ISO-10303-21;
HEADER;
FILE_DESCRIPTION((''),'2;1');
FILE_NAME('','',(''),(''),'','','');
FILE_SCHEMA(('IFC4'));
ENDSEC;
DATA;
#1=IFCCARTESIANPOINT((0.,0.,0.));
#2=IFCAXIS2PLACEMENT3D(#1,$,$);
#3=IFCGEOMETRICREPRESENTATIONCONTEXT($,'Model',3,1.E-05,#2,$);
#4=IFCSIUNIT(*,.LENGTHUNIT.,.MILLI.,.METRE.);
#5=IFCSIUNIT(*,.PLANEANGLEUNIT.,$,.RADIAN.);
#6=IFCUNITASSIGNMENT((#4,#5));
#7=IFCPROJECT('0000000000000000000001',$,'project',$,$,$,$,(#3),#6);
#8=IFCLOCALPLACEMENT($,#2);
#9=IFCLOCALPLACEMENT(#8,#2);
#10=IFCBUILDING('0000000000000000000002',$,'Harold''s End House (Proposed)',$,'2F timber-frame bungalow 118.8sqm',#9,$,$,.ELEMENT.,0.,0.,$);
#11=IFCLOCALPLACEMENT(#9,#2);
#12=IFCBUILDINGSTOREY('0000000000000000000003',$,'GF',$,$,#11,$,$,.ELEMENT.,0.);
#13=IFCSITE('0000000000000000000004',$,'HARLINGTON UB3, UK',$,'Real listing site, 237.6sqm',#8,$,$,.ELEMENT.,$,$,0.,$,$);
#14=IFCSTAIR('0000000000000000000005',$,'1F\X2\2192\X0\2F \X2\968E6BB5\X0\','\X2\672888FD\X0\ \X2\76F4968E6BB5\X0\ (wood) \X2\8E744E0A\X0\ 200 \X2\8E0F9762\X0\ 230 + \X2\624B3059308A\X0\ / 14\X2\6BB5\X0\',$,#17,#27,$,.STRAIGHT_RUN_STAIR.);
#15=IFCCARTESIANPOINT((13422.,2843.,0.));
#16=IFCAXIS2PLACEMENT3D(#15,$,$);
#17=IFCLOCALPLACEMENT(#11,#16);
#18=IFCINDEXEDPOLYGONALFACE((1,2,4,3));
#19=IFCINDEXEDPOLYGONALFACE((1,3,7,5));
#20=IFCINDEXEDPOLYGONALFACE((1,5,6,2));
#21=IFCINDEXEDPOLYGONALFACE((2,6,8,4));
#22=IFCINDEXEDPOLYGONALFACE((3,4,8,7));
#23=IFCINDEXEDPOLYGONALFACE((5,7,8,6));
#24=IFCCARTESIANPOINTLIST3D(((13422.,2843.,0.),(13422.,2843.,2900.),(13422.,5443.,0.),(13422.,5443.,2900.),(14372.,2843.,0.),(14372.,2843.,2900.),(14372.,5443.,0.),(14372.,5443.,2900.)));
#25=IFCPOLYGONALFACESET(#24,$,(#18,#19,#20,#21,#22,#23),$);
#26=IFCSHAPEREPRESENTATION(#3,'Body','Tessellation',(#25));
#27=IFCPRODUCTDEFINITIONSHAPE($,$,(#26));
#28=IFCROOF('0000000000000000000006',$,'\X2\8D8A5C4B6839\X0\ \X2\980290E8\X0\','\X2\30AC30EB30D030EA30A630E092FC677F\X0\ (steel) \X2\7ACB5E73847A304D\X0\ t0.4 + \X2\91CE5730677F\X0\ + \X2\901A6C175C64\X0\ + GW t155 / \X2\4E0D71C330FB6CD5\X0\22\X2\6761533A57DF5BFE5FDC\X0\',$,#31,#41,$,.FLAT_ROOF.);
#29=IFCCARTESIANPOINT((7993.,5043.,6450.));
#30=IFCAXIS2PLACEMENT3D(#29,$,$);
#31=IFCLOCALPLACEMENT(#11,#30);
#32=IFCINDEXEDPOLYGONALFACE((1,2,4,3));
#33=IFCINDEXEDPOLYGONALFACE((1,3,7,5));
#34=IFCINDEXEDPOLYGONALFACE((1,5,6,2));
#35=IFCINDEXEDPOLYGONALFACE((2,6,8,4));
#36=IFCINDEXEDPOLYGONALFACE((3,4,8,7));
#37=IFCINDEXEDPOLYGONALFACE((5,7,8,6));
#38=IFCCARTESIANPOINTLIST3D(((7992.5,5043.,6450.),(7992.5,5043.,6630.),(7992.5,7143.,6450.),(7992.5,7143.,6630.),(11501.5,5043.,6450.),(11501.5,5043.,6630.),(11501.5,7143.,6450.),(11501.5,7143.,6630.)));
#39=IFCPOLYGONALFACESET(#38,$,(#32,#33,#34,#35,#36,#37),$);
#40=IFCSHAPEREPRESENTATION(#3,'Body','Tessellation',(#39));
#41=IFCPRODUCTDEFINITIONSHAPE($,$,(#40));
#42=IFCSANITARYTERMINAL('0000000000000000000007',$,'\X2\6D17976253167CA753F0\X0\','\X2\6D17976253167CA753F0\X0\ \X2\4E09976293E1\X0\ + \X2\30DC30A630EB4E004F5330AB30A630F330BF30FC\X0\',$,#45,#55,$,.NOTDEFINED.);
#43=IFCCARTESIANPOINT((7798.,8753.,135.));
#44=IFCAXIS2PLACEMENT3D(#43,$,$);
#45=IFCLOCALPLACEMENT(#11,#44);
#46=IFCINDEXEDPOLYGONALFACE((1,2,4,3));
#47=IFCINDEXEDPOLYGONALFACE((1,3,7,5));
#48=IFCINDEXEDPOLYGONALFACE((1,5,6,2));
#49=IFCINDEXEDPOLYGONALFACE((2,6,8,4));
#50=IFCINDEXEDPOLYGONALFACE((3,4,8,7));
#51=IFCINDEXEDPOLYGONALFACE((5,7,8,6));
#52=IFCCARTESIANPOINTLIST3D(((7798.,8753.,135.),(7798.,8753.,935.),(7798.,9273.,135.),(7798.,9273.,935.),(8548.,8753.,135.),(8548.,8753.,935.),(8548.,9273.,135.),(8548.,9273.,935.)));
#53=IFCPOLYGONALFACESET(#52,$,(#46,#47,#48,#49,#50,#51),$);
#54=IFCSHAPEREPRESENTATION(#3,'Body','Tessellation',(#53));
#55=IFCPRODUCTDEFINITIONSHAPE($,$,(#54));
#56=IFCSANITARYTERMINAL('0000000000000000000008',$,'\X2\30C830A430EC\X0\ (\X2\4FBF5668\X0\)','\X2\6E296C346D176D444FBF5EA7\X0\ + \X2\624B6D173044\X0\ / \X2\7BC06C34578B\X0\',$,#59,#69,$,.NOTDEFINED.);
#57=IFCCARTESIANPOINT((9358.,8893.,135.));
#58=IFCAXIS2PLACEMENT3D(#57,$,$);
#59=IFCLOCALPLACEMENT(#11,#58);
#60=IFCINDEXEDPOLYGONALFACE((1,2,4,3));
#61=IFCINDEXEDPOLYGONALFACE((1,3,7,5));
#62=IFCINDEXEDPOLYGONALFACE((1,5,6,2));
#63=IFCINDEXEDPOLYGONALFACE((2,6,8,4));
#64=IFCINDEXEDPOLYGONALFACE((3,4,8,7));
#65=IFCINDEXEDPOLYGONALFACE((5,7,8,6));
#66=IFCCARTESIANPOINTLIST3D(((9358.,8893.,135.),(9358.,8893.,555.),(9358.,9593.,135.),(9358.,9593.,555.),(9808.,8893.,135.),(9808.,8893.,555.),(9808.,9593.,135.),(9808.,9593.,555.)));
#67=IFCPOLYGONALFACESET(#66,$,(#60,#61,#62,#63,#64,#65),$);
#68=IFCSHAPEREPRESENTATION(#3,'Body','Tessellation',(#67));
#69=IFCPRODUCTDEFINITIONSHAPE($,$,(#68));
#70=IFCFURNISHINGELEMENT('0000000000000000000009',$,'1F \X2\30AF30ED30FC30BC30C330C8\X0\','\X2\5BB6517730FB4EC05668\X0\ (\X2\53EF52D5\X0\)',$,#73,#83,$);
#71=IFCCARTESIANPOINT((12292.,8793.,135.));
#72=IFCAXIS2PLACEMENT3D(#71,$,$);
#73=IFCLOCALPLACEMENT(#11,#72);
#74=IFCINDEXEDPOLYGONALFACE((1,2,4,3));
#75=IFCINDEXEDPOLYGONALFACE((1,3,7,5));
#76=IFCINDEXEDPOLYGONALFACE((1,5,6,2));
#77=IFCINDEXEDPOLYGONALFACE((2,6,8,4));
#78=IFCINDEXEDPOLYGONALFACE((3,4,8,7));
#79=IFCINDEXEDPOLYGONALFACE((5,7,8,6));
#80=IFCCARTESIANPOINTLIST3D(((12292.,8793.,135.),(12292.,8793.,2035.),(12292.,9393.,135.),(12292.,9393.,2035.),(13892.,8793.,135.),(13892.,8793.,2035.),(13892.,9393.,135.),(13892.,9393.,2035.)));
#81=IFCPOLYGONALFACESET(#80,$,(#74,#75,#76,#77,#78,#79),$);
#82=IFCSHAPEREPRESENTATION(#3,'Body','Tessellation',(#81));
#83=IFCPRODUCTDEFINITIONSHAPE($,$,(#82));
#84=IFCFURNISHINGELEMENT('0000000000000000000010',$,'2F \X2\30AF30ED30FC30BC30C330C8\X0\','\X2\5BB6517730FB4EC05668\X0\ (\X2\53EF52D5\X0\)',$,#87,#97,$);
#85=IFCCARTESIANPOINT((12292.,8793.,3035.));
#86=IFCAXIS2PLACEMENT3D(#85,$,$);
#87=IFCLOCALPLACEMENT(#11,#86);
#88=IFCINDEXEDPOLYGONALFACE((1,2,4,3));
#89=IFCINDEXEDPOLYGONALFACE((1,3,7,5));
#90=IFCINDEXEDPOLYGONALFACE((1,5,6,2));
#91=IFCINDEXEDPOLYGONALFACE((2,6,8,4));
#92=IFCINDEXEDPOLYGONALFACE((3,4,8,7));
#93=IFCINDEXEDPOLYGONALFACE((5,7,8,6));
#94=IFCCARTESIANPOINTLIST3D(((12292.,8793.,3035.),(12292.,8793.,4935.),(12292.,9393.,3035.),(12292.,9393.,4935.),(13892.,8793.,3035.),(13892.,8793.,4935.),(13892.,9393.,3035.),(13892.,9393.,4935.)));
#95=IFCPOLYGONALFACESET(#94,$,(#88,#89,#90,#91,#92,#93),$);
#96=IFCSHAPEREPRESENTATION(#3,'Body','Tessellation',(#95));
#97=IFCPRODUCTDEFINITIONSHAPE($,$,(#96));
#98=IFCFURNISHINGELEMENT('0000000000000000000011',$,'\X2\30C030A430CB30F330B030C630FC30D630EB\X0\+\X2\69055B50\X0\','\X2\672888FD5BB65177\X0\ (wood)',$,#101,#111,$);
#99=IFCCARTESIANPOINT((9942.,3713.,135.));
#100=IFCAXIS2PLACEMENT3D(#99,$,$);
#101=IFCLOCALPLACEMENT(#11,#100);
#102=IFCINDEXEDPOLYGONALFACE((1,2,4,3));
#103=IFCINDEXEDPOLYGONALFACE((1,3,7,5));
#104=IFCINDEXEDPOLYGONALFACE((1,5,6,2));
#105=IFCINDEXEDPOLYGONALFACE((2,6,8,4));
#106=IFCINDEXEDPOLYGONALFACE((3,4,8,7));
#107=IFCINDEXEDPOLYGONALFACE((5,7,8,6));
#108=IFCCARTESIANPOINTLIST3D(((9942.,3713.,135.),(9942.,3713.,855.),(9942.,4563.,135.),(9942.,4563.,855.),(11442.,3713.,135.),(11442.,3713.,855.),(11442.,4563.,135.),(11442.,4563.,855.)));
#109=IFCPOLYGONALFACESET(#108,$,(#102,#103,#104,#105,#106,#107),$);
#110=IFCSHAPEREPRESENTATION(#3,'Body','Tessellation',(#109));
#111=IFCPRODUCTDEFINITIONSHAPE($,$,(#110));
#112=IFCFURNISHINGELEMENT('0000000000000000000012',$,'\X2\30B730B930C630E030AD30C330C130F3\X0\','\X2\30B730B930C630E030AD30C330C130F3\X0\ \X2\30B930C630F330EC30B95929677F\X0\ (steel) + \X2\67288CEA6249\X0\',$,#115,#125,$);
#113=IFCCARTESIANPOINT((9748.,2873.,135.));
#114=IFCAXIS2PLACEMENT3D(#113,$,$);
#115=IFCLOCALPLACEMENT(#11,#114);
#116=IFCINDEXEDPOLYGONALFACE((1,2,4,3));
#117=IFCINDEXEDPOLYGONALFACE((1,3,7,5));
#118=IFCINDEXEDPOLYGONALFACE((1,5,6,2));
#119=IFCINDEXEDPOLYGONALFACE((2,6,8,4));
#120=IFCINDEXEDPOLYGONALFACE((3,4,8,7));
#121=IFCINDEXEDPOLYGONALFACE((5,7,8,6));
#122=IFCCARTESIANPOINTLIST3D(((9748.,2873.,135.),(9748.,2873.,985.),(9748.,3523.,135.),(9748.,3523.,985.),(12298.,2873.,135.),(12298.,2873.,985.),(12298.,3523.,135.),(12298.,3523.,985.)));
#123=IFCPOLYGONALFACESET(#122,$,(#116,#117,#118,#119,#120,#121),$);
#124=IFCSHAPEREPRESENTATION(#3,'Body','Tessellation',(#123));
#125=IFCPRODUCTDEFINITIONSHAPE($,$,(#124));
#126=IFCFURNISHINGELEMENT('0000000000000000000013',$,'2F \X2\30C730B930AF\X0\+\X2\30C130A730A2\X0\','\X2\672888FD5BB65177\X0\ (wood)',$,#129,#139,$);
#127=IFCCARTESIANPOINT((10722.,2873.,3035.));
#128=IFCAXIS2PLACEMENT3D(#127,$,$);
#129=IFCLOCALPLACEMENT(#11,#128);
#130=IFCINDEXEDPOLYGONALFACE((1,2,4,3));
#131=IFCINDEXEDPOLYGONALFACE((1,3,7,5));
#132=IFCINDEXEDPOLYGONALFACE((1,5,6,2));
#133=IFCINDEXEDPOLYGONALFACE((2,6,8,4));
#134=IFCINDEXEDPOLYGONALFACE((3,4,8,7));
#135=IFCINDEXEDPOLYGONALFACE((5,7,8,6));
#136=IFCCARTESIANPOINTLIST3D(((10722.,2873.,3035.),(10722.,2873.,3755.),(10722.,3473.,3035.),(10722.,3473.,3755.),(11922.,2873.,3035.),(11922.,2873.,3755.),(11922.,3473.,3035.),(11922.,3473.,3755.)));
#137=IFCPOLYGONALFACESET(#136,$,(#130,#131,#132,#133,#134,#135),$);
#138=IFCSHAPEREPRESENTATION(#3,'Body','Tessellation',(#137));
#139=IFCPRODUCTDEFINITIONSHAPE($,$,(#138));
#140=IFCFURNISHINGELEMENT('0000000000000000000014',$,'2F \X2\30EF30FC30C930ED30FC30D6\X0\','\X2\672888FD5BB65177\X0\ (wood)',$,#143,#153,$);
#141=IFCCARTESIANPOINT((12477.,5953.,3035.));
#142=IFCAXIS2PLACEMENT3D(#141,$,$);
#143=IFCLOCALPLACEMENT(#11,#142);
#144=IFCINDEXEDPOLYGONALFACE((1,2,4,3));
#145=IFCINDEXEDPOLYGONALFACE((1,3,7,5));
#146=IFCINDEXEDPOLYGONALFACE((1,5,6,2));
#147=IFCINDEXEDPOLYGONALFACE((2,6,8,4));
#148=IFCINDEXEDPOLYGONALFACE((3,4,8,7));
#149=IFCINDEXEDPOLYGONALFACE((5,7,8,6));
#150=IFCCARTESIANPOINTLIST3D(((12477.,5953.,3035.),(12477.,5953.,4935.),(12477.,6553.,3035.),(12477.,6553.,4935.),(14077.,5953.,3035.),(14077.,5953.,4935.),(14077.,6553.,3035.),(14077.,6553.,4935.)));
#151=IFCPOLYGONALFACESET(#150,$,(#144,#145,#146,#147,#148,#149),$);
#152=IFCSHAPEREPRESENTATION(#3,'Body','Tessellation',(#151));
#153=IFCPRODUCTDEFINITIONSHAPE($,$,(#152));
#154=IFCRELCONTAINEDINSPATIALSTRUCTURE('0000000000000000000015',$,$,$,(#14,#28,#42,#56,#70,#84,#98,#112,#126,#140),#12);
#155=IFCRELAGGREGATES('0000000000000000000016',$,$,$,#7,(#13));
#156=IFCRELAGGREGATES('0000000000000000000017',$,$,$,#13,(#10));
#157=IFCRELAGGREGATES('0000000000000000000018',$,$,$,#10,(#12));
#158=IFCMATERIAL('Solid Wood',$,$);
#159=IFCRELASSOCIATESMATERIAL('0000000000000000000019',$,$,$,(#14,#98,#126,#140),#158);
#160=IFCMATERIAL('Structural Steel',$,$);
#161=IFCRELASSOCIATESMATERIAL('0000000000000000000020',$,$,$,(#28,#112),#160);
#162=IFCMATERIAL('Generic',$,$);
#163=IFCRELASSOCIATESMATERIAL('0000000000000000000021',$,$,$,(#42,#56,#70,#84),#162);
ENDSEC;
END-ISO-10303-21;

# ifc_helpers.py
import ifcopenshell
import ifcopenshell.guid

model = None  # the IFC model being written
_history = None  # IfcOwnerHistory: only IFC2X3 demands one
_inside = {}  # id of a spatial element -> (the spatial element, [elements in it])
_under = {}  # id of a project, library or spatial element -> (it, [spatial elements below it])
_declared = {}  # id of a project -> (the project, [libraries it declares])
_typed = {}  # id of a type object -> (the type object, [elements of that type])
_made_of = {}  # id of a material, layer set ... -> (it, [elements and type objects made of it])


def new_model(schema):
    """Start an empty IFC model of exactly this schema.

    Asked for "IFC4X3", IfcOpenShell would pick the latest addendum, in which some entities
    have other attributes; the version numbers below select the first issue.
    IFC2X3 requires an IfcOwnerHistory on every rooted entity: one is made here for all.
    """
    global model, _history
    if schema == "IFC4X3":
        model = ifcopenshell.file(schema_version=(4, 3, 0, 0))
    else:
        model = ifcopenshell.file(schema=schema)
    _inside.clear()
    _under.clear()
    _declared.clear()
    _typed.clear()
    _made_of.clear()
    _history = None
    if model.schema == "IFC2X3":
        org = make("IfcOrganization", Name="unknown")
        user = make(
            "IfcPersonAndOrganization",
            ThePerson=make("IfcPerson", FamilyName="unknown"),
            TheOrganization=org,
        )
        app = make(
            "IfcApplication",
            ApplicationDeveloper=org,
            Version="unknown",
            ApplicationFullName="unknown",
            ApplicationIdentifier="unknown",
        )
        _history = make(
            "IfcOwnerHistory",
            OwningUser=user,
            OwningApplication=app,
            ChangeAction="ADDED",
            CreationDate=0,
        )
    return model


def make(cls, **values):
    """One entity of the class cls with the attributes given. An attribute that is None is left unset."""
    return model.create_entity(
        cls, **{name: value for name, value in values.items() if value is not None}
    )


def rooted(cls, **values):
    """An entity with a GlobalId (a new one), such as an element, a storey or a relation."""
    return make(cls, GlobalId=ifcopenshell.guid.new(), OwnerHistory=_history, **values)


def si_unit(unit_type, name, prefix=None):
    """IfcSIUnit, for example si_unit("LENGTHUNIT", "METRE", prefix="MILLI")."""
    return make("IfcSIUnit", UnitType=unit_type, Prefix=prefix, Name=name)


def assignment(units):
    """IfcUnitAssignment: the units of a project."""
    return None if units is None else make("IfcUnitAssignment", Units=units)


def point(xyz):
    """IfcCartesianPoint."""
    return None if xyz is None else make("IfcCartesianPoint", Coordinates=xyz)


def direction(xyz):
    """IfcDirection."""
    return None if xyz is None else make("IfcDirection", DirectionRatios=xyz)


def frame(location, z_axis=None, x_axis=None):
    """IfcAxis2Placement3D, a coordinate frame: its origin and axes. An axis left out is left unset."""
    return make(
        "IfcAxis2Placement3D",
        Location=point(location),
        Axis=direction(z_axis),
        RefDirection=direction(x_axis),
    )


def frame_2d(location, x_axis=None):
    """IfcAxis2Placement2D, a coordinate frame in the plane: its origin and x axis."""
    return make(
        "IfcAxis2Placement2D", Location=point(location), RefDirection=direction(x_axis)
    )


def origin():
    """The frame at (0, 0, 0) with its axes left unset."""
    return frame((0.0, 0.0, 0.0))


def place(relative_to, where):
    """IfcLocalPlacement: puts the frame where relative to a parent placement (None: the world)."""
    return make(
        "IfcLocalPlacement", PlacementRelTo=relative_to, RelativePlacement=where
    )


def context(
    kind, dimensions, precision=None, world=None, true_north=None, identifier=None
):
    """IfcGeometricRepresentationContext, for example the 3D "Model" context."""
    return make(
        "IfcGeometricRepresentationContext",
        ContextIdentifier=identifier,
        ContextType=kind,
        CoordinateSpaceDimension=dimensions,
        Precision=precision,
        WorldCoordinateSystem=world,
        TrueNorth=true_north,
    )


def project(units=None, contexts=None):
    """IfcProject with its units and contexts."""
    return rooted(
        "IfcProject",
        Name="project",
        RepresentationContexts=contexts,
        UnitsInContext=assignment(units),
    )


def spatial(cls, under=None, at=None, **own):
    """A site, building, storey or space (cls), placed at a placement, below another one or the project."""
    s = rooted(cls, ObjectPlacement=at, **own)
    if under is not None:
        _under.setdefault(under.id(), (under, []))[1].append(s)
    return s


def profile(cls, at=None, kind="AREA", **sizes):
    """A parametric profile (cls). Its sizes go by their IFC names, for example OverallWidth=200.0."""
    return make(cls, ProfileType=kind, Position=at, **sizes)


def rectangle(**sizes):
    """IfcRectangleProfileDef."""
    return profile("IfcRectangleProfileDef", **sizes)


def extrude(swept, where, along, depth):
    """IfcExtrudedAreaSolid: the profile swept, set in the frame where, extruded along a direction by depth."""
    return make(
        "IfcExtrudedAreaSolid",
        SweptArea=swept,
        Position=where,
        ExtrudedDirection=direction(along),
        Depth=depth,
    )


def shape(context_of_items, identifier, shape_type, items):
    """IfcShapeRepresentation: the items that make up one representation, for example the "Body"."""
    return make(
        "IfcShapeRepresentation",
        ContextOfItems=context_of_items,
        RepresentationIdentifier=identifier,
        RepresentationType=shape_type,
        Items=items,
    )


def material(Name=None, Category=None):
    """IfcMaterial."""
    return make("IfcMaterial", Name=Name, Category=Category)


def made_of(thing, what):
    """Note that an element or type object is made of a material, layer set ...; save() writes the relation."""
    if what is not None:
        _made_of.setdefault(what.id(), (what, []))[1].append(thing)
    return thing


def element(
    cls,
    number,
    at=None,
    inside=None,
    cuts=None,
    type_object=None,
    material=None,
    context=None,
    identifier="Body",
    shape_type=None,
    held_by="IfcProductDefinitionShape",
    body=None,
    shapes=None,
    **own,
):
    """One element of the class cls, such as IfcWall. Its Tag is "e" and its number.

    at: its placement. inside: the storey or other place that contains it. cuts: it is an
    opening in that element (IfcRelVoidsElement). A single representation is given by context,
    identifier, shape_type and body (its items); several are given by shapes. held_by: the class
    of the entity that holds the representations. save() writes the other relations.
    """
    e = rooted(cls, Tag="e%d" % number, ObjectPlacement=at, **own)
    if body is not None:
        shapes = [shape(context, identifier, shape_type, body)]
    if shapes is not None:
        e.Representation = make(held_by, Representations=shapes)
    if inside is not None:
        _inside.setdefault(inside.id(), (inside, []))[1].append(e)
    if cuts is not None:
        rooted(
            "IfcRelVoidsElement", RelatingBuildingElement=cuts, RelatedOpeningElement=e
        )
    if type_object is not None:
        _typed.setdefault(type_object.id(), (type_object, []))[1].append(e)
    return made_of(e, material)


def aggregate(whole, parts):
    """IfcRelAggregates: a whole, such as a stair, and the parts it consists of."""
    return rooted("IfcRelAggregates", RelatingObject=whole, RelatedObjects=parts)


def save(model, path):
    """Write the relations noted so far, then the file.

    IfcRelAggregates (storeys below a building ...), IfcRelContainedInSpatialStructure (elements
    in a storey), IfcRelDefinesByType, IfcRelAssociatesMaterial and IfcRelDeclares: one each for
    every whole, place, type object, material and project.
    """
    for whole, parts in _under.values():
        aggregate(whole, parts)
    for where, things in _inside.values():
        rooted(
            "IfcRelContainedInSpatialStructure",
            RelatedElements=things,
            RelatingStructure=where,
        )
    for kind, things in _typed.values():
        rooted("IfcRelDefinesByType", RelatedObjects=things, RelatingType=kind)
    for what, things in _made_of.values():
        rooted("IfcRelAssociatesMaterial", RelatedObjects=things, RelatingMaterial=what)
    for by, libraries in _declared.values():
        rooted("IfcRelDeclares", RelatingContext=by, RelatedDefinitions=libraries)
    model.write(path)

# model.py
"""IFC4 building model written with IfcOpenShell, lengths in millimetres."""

from ifc_helpers import new_model, si_unit, frame, frame_2d, origin, place, context, project, spatial, rectangle, extrude, material, element, save


model = new_model("IFC4")

# Units and contexts
model_context = context("Model", 3, precision=1e-05, world=origin())
ifc_project = project(units=[si_unit("LENGTHUNIT", "METRE", prefix="MILLI"), si_unit("PLANEANGLEUNIT", "RADIAN")], contexts=[model_context])

# Site, building, storey
site_placement = place(None, origin())
site = spatial("IfcSite", under=ifc_project, at=site_placement, Name="HARLINGTON UB3, UK", ObjectType="Real listing site, 237.6sqm", CompositionType="ELEMENT", RefElevation=0.0)
building_placement = place(site_placement, origin())
building = spatial("IfcBuilding", under=site, at=building_placement, Name="Harold's End House (Proposed)", ObjectType="2F timber-frame bungalow 118.8sqm", CompositionType="ELEMENT", ElevationOfRefHeight=0.0, ElevationOfTerrain=0.0)
storey_placement = place(building_placement, origin())
storey = spatial("IfcBuildingStorey", under=building, at=storey_placement, Name="GF", CompositionType="ELEMENT", Elevation=0.0)

# Shared definitions
ifc_material_1 = material(Name="Solid Wood")

# Stair
stair_placement = place(storey_placement, frame((13422.0, 2843.0, 0.0)))
element("IfcStair", 1, at=stair_placement, inside=storey, material=ifc_material_1, Name="1F→2F 階段", Description="木製 直階段 (wood) 蹴上 200 踏面 230 + 手すり / 14段", PredefinedType="STRAIGHT_RUN_STAIR", context=model_context, shape_type="SweptSolid", body=[
    extrude(rectangle(XDim=950.0, YDim=2600.0, at=frame_2d((475.0, 1300.0))), frame((13422.0, 2843.0, 0.0)), (0.0, 0.0, 1.0), 2900.0),
])

# Roof
ifc_material_2 = material(Name="Structural Steel")
roof_placement = place(storey_placement, frame((7993.0, 5043.0, 6450.0)))
element("IfcRoof", 2, at=roof_placement, inside=storey, material=ifc_material_2, Name="越屋根 頂部", Description="ガルバリウム鋼板 (steel) 立平葺き t0.4 + 野地板 + 通気層 + GW t155 / 不燃・法22条区域対応", PredefinedType="FLAT_ROOF", context=model_context, shape_type="SweptSolid", body=[
    extrude(rectangle(XDim=3509.0, YDim=2100.0, at=frame_2d((1754.0, 1050.0))), frame((7993.0, 5043.0, 6450.0)), (0.0, 0.0, 1.0), 180.0),
])

# Sanitary terminals
ifc_material_3 = material(Name="Generic")
sanitary_terminal_1_placement = place(storey_placement, frame((7798.0, 8753.0, 135.0)))
element("IfcSanitaryTerminal", 3, at=sanitary_terminal_1_placement, inside=storey, material=ifc_material_3, Name="洗面化粧台", Description="洗面化粧台 三面鏡 + ボウル一体カウンター", PredefinedType="NOTDEFINED", context=model_context, shape_type="SweptSolid", body=[
    extrude(rectangle(XDim=750.0, YDim=520.0, at=frame_2d((375.0, 260.0))), frame((7798.0, 8753.0, 135.0)), (0.0, 0.0, 1.0), 800.0),
])
sanitary_terminal_2_placement = place(storey_placement, frame((9358.0, 8893.0, 135.0)))
element("IfcSanitaryTerminal", 4, at=sanitary_terminal_2_placement, inside=storey, material=ifc_material_3, Name="トイレ (便器)", Description="温水洗浄便座 + 手洗い / 節水型", PredefinedType="NOTDEFINED", context=model_context, shape_type="SweptSolid", body=[
    extrude(rectangle(XDim=450.0, YDim=700.0, at=frame_2d((225.0, 350.0))), frame((9358.0, 8893.0, 135.0)), (0.0, 0.0, 1.0), 420.0),
])

# Furnishing elements
furnishing_1_placement = place(storey_placement, frame((12292.0, 8793.0, 135.0)))
element("IfcFurnishingElement", 5, at=furnishing_1_placement, inside=storey, material=ifc_material_3, Name="1F クローゼット", Description="家具・什器 (可動)", context=model_context, shape_type="SweptSolid", body=[
    extrude(rectangle(XDim=1600.0, YDim=600.0, at=frame_2d((800.0, 300.0))), frame((12292.0, 8793.0, 135.0)), (0.0, 0.0, 1.0), 1900.0),
])
furnishing_2_placement = place(storey_placement, frame((12292.0, 8793.0, 3035.0)))
element("IfcFurnishingElement", 6, at=furnishing_2_placement, inside=storey, material=ifc_material_3, Name="2F クローゼット", Description="家具・什器 (可動)", context=model_context, shape_type="SweptSolid", body=[
    extrude(rectangle(XDim=1600.0, YDim=600.0, at=frame_2d((800.0, 300.0))), frame((12292.0, 8793.0, 3035.0)), (0.0, 0.0, 1.0), 1900.0),
])
furnishing_3_placement = place(storey_placement, frame((9942.0, 3713.0, 135.0)))
element("IfcFurnishingElement", 7, at=furnishing_3_placement, inside=storey, material=ifc_material_1, Name="ダイニングテーブル+椅子", Description="木製家具 (wood)", context=model_context, shape_type="SweptSolid", body=[
    extrude(rectangle(XDim=1500.0, YDim=850.0, at=frame_2d((750.0, 425.0))), frame((9942.0, 3713.0, 135.0)), (0.0, 0.0, 1.0), 720.0),
])
furnishing_4_placement = place(storey_placement, frame((9748.0, 2873.0, 135.0)))
element("IfcFurnishingElement", 8, at=furnishing_4_placement, inside=storey, material=ifc_material_2, Name="システムキッチン", Description="システムキッチン ステンレス天板 (steel) + 木質扉", context=model_context, shape_type="SweptSolid", body=[
    extrude(rectangle(XDim=2550.0, YDim=650.0, at=frame_2d((1275.0, 325.0))), frame((9748.0, 2873.0, 135.0)), (0.0, 0.0, 1.0), 850.0),
])
furnishing_5_placement = place(storey_placement, frame((10722.0, 2873.0, 3035.0)))
element("IfcFurnishingElement", 9, at=furnishing_5_placement, inside=storey, material=ifc_material_1, Name="2F デスク+チェア", Description="木製家具 (wood)", context=model_context, shape_type="SweptSolid", body=[
    extrude(rectangle(XDim=1200.0, YDim=600.0, at=frame_2d((600.0, 300.0))), frame((10722.0, 2873.0, 3035.0)), (0.0, 0.0, 1.0), 720.0),
])
furnishing_6_placement = place(storey_placement, frame((12477.0, 5953.0, 3035.0)))
element("IfcFurnishingElement", 10, at=furnishing_6_placement, inside=storey, material=ifc_material_1, Name="2F ワードローブ", Description="木製家具 (wood)", context=model_context, shape_type="SweptSolid", body=[
    extrude(rectangle(XDim=1600.0, YDim=600.0, at=frame_2d((800.0, 300.0))), frame((12477.0, 5953.0, 3035.0)), (0.0, 0.0, 1.0), 1900.0),
])

save(model, "model.ifc")
